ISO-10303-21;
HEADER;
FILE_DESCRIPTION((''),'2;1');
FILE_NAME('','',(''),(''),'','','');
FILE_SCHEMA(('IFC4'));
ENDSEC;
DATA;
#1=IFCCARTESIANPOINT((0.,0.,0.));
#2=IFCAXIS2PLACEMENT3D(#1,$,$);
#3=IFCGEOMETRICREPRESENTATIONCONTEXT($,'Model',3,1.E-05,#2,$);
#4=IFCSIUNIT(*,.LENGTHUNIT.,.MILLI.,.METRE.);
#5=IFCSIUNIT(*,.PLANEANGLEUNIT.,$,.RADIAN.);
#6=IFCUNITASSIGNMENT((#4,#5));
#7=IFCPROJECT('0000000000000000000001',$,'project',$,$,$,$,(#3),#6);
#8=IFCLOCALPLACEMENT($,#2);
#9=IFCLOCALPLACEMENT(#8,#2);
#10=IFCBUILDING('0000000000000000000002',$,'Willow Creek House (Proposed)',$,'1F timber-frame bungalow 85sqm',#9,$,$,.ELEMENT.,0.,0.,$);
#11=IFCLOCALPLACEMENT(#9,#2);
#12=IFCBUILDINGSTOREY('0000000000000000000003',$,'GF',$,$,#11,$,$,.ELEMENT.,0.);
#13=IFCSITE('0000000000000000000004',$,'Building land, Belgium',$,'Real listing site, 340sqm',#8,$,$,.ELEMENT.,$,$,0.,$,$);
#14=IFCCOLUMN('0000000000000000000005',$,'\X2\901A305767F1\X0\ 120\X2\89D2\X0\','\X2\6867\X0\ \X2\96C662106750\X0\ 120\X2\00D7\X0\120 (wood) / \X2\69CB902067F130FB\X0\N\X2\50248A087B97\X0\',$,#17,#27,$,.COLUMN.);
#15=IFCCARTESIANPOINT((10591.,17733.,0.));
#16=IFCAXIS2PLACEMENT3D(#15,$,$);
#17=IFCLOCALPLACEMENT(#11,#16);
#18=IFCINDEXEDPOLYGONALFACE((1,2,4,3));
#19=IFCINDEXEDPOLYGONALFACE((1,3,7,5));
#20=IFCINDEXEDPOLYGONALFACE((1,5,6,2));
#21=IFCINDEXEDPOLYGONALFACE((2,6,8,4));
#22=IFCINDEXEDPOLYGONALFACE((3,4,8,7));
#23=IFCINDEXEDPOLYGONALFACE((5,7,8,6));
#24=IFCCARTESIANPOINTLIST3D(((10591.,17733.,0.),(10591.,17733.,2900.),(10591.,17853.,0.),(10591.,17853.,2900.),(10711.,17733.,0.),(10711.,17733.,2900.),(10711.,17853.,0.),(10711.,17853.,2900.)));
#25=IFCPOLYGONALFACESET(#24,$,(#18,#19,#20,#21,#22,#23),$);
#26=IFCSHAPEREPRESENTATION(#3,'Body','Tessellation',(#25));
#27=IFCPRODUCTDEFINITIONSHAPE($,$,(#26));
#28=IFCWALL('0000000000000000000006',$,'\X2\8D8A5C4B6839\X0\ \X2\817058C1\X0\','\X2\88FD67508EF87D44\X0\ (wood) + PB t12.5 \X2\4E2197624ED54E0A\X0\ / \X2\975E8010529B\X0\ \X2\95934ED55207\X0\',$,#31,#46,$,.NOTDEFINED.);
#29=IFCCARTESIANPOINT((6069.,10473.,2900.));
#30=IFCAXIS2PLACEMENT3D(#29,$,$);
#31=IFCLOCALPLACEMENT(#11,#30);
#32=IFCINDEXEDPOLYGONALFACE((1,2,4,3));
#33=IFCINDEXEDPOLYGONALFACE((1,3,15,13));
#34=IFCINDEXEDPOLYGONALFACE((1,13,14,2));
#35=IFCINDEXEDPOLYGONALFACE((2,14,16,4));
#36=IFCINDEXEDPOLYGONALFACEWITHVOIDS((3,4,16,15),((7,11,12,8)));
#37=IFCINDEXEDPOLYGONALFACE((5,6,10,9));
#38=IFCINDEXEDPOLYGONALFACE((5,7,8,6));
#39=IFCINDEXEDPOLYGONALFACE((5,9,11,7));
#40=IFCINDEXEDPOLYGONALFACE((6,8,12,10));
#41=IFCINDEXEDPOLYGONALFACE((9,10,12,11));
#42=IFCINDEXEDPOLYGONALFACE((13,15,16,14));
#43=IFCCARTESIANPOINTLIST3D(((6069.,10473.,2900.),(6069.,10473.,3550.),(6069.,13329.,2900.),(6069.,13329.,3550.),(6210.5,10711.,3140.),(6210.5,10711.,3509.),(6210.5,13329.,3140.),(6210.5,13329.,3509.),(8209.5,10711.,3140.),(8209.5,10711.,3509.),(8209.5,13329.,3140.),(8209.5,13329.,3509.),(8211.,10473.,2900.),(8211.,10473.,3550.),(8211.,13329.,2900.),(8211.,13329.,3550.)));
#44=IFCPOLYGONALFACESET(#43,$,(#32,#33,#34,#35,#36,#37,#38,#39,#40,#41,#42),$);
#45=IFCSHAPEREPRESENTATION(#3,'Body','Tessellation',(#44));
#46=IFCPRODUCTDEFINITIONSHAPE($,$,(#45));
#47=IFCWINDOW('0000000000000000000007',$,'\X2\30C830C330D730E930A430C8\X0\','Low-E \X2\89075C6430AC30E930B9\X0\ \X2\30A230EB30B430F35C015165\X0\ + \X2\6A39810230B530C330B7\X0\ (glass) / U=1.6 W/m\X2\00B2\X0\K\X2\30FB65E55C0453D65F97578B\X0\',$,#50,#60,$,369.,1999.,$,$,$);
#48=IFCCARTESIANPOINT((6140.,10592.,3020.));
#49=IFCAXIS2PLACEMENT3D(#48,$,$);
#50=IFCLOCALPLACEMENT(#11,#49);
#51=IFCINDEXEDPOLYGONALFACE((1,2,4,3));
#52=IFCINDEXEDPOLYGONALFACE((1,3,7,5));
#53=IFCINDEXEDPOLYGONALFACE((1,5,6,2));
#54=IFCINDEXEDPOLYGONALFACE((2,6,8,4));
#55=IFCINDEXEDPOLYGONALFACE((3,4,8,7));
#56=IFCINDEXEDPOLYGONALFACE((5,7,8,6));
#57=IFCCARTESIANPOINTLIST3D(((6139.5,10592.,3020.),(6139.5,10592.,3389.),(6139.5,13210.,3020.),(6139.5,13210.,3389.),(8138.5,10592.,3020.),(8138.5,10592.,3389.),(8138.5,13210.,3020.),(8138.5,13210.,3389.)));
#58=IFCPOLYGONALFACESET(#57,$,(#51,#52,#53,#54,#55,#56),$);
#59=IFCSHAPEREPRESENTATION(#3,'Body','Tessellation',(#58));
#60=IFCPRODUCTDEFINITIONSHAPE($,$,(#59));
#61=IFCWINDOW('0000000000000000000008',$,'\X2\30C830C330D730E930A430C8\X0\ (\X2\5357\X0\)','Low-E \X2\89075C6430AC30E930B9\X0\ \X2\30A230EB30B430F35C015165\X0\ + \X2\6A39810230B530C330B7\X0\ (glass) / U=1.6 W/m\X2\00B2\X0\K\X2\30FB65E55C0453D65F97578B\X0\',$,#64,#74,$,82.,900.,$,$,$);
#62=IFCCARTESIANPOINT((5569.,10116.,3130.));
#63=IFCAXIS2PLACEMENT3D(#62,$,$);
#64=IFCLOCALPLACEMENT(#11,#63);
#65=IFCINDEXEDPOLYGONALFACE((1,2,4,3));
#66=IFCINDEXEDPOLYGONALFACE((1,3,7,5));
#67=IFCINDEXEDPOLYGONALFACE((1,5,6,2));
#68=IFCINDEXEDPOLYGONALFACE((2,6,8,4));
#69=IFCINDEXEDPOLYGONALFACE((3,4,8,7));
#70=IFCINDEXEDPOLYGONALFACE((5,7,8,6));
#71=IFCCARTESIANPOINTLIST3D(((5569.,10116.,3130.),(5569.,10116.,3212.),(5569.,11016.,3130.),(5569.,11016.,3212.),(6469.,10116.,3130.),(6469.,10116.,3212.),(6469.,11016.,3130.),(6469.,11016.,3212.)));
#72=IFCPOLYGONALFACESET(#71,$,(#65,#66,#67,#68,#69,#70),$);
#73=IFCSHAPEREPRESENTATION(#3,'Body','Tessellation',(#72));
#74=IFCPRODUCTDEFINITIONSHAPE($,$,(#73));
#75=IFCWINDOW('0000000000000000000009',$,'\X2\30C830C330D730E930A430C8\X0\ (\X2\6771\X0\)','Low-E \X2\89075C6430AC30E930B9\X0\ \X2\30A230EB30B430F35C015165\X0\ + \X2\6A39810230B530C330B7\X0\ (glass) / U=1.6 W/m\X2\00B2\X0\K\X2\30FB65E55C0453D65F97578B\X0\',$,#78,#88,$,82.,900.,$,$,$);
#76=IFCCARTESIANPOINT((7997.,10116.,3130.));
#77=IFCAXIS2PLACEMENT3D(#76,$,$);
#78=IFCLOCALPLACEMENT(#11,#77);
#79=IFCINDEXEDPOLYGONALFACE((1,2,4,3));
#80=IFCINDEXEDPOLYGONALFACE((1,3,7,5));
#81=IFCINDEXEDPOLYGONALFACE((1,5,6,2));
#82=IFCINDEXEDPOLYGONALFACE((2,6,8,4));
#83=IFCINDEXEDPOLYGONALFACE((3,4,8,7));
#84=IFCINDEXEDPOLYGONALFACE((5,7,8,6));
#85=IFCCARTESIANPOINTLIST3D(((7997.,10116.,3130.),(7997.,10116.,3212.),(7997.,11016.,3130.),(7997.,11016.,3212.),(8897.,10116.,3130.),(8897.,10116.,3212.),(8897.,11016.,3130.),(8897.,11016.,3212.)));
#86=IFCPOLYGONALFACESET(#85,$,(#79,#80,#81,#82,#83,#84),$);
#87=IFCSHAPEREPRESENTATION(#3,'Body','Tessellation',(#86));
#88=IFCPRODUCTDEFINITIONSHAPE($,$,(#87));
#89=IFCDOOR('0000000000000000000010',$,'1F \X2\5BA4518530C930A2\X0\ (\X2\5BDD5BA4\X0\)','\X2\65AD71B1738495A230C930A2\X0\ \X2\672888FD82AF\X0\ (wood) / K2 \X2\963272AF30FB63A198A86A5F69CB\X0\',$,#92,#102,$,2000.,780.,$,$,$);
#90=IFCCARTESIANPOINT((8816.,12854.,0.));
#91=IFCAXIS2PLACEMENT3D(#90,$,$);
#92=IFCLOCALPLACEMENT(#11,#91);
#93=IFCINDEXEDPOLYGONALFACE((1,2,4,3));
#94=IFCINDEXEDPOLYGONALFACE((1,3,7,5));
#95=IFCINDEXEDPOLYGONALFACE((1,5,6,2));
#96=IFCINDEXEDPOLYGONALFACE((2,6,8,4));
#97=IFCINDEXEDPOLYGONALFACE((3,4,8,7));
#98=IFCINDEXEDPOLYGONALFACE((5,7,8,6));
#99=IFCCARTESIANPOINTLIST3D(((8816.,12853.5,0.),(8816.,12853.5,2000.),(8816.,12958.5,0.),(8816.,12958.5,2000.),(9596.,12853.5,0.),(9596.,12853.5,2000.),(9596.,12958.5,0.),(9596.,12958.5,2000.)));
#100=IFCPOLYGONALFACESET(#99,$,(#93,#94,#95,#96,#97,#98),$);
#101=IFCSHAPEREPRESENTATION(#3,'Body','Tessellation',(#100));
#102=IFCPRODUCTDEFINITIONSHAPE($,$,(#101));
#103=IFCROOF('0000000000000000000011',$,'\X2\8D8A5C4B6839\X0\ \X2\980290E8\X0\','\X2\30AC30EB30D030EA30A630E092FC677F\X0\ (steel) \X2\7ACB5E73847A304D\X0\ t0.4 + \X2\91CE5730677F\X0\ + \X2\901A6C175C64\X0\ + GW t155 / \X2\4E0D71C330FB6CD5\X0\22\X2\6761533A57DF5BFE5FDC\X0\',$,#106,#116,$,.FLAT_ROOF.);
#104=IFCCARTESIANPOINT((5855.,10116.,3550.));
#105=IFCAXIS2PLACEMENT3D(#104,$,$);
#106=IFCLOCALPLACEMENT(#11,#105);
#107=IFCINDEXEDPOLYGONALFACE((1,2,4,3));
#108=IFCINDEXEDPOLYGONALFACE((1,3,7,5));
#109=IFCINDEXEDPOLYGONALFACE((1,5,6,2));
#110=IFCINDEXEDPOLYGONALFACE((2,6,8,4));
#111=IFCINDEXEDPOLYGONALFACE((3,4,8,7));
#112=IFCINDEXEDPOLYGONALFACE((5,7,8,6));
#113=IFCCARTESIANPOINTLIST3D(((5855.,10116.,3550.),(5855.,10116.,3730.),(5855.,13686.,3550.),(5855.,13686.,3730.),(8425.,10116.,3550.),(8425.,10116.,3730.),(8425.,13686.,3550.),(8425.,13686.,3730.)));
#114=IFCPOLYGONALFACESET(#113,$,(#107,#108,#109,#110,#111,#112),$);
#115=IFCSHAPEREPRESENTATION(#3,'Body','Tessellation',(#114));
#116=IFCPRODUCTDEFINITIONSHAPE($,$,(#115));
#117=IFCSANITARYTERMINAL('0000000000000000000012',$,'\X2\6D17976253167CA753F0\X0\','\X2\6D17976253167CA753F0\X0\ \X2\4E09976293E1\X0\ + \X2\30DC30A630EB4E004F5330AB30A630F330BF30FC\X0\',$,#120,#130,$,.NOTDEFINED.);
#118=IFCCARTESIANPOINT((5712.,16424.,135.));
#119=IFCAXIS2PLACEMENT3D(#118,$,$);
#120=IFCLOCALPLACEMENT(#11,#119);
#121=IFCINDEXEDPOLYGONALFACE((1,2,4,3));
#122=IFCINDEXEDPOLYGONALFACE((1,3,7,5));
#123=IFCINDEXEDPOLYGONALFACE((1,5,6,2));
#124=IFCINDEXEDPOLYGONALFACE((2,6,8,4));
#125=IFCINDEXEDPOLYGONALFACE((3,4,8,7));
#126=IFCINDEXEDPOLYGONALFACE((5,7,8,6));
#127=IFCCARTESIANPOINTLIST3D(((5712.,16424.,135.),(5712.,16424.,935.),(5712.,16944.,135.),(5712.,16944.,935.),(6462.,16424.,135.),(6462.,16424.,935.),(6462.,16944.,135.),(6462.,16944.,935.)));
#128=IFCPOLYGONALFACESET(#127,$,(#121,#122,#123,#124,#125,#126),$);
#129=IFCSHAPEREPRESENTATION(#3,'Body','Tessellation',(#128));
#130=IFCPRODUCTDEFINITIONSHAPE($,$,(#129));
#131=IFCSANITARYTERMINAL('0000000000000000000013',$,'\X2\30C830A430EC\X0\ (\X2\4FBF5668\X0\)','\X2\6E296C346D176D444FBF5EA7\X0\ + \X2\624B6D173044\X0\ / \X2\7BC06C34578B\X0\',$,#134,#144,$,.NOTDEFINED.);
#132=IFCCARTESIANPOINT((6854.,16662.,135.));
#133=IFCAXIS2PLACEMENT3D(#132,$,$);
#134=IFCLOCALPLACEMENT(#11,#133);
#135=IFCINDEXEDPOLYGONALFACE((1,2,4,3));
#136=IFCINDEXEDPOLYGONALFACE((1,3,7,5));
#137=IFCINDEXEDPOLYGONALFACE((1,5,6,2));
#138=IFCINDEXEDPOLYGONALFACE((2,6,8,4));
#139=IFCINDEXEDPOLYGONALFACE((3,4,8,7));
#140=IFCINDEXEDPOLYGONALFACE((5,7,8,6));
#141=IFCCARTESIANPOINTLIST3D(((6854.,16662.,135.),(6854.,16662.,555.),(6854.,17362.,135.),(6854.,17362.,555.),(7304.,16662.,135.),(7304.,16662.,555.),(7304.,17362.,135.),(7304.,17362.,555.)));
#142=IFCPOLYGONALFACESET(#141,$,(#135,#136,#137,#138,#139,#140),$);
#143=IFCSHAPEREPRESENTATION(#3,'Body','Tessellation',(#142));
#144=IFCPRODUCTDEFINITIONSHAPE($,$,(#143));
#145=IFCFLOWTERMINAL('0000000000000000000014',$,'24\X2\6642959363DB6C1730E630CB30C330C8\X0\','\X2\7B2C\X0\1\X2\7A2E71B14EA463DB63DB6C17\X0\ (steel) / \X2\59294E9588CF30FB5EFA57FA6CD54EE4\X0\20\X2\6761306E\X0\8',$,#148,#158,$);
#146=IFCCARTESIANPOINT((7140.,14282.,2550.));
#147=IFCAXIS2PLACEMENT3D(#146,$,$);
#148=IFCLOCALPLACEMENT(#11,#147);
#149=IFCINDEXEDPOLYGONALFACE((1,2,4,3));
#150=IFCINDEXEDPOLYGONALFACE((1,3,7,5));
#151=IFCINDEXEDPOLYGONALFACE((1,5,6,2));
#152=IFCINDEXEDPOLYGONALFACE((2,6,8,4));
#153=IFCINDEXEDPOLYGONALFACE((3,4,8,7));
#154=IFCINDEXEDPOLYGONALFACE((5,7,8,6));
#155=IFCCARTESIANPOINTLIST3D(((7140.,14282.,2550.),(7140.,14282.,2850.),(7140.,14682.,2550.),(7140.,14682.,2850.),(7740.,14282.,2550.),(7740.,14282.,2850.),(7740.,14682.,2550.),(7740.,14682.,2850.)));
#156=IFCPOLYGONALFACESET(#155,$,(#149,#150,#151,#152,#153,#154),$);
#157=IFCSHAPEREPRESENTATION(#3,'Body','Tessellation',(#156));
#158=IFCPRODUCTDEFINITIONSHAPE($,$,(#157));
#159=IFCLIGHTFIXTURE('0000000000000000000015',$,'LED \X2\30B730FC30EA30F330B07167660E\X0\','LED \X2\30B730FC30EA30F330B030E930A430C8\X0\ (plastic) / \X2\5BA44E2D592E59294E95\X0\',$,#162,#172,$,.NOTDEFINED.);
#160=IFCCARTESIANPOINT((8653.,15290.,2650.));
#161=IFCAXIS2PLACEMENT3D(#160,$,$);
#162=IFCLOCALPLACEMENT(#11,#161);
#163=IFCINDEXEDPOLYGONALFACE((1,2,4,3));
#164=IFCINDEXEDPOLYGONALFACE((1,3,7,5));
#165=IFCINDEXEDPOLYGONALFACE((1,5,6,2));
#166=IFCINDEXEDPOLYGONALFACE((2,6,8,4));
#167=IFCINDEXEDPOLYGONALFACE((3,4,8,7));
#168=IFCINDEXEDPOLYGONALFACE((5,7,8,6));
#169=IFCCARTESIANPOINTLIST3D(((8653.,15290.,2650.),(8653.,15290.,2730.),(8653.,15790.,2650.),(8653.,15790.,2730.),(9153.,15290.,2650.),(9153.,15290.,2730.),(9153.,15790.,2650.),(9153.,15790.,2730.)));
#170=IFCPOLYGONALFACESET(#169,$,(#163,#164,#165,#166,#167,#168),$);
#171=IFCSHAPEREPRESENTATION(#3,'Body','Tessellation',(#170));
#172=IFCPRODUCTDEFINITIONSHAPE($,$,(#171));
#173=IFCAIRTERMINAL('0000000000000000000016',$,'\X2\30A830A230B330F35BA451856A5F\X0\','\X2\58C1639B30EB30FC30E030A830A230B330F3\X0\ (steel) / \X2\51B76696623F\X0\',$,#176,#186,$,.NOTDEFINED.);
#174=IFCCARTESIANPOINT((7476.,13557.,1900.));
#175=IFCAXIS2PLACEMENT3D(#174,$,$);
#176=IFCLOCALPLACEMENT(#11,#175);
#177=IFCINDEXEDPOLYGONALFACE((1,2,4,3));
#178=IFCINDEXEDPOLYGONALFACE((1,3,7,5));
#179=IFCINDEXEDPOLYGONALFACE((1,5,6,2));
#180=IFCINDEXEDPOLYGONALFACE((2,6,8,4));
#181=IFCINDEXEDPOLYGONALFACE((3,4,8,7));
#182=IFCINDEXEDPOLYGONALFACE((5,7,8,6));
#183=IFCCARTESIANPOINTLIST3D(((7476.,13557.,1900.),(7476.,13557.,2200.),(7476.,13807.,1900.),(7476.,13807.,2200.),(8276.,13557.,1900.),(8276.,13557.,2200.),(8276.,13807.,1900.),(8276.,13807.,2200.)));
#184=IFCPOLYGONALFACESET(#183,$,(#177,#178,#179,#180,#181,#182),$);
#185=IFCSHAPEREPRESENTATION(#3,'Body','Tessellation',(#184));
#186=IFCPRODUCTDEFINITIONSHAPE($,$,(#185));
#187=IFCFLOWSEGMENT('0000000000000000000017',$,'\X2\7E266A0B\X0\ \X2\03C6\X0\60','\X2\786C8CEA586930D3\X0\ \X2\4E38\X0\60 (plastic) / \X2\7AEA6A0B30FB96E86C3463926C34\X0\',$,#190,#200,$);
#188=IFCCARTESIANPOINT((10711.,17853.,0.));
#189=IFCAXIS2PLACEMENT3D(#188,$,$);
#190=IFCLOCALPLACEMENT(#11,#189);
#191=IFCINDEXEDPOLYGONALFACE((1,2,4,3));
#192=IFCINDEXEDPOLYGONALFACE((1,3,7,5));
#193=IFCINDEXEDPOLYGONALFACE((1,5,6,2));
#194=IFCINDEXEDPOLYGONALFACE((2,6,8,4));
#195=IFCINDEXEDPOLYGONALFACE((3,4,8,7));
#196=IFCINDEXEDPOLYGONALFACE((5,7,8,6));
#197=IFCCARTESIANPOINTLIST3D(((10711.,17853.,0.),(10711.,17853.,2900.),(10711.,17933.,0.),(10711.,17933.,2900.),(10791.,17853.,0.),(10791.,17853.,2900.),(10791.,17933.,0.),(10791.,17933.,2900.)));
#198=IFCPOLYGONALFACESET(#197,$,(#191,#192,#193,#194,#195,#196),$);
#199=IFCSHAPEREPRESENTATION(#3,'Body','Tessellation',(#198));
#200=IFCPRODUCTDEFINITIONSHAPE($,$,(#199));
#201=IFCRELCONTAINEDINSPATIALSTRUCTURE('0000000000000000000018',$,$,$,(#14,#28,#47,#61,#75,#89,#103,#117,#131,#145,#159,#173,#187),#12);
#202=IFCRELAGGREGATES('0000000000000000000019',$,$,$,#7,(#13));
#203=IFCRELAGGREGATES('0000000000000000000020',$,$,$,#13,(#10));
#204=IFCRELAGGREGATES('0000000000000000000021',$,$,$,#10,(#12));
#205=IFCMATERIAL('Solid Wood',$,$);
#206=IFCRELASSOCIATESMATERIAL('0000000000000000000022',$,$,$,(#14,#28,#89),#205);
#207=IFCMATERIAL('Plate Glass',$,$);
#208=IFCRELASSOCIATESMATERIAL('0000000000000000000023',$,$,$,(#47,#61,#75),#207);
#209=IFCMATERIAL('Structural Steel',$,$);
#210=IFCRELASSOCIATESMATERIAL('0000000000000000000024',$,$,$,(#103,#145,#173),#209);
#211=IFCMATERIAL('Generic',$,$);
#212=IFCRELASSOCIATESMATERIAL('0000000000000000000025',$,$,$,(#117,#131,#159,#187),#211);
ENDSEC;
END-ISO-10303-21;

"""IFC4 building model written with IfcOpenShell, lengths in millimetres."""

from ifc_helpers import new_model, si_unit, frame, frame_2d, origin, place, context, project, spatial, rectangle, extrude, material, element, fill, save


model = new_model("IFC4")

# Units and contexts
model_context = context("Model", 3, precision=1e-05, world=origin())
ifc_project = project(units=[si_unit("LENGTHUNIT", "METRE", prefix="MILLI"), si_unit("PLANEANGLEUNIT", "RADIAN")], contexts=[model_context])

# Site, building, storey
site_placement = place(None, origin())
site = spatial("IfcSite", under=ifc_project, at=site_placement, Name="Building land, Belgium", ObjectType="Real listing site, 340sqm", CompositionType="ELEMENT", RefElevation=0.0)
building_placement = place(site_placement, origin())
building = spatial("IfcBuilding", under=site, at=building_placement, Name="Willow Creek House (Proposed)", ObjectType="1F timber-frame bungalow 85sqm", CompositionType="ELEMENT", ElevationOfRefHeight=0.0, ElevationOfTerrain=0.0)
storey_placement = place(building_placement, origin())
storey = spatial("IfcBuildingStorey", under=building, at=storey_placement, Name="GF", CompositionType="ELEMENT", Elevation=0.0)

# Column
ifc_material_1 = material(Name="Solid Wood")
column_1_placement = place(storey_placement, frame((10591.0, 17733.0, 0.0)))
element("IfcColumn", 1, at=column_1_placement, inside=storey, material=ifc_material_1, Name="通し柱 120角", Description="桧 集成材 120×120 (wood) / 構造柱・N値計算", PredefinedType="COLUMN", context=model_context, shape_type="SweptSolid", body=[
    extrude(rectangle(XDim=120.0, YDim=120.0, at=frame_2d((60.0, 60.0))), frame((10591.0, 17733.0, 0.0)), (0.0, 0.0, 1.0), 2900.0),
])

# Wall, openings, windows
wall_1_placement = place(storey_placement, frame((6069.0, 10473.0, 2900.0)))
wall_1 = element("IfcWall", 2, at=wall_1_placement, inside=storey, material=ifc_material_1, Name="越屋根 腰壁", Description="製材軸組 (wood) + PB t12.5 両面仕上 / 非耐力 間仕切", PredefinedType="NOTDEFINED", context=model_context, shape_type="SweptSolid", body=[
    extrude(rectangle(XDim=2142.0, YDim=2856.0, at=frame_2d((1071.0, 1428.0))), frame((6069.0, 10473.0, 2900.0)), (0.0, 0.0, 1.0), 650.0),
])
opening_1_placement = place(storey_placement, frame((6140.0, 10592.0, 3020.0)))
opening_1 = element("IfcOpeningElement", 3, at=opening_1_placement, cuts=wall_1, PredefinedType="NOTDEFINED", context=model_context, shape_type="SweptSolid", body=[
    extrude(rectangle(XDim=1999.0, YDim=2618.0, at=frame_2d((999.0, 1309.0))), frame((6140.0, 10592.0, 3020.0)), (0.0, 0.0, 1.0), 369.0),
])
opening_2_placement = place(storey_placement, frame((5569.0, 10116.0, 3130.0)))
opening_2 = element("IfcOpeningElement", 4, at=opening_2_placement, cuts=wall_1, PredefinedType="NOTDEFINED", context=model_context, shape_type="SweptSolid", body=[
    extrude(rectangle(XDim=900.0, YDim=900.0, at=frame_2d((450.0, 450.0))), frame((5569.0, 10116.0, 3130.0)), (0.0, 0.0, 1.0), 82.0),
])
opening_3_placement = place(storey_placement, frame((7997.0, 10116.0, 3130.0)))
opening_3 = element("IfcOpeningElement", 5, at=opening_3_placement, cuts=wall_1, PredefinedType="NOTDEFINED", context=model_context, shape_type="SweptSolid", body=[
    extrude(rectangle(XDim=900.0, YDim=900.0, at=frame_2d((450.0, 450.0))), frame((7997.0, 10116.0, 3130.0)), (0.0, 0.0, 1.0), 82.0),
])
ifc_material_2 = material(Name="Plate Glass")
window_1_placement = place(storey_placement, frame((6140.0, 10592.0, 3020.0)))
window_1 = element("IfcWindow", 6, at=window_1_placement, inside=storey, material=ifc_material_2, Name="トップライト", Description="Low-E 複層ガラス アルゴン封入 + 樹脂サッシ (glass) / U=1.6 W/m²K・日射取得型", OverallHeight=369.0, OverallWidth=1999.0, context=model_context, shape_type="SweptSolid", body=[
    extrude(rectangle(XDim=1999.0, YDim=2618.0, at=frame_2d((999.0, 1309.0))), frame((6140.0, 10592.0, 3020.0)), (0.0, 0.0, 1.0), 369.0),
])
fill(opening_1, window_1)
window_2_placement = place(storey_placement, frame((5569.0, 10116.0, 3130.0)))
window_2 = element("IfcWindow", 7, at=window_2_placement, inside=storey, material=ifc_material_2, Name="トップライト (南)", Description="Low-E 複層ガラス アルゴン封入 + 樹脂サッシ (glass) / U=1.6 W/m²K・日射取得型", OverallHeight=82.0, OverallWidth=900.0, context=model_context, shape_type="SweptSolid", body=[
    extrude(rectangle(XDim=900.0, YDim=900.0, at=frame_2d((450.0, 450.0))), frame((5569.0, 10116.0, 3130.0)), (0.0, 0.0, 1.0), 82.0),
])
fill(opening_2, window_2)
window_3_placement = place(storey_placement, frame((7997.0, 10116.0, 3130.0)))
window_3 = element("IfcWindow", 8, at=window_3_placement, inside=storey, material=ifc_material_2, Name="トップライト (東)", Description="Low-E 複層ガラス アルゴン封入 + 樹脂サッシ (glass) / U=1.6 W/m²K・日射取得型", OverallHeight=82.0, OverallWidth=900.0, context=model_context, shape_type="SweptSolid", body=[
    extrude(rectangle(XDim=900.0, YDim=900.0, at=frame_2d((450.0, 450.0))), frame((7997.0, 10116.0, 3130.0)), (0.0, 0.0, 1.0), 82.0),
])
fill(opening_3, window_3)

# Door
door_placement = place(storey_placement, frame((8816.0, 12854.0, 0.0)))
element("IfcDoor", 9, at=door_placement, inside=storey, material=ifc_material_1, Name="1F 室内ドア (寝室)", Description="断熱玄関ドア 木製芯 (wood) / K2 防犯・採風機構", OverallHeight=2000.0, OverallWidth=780.0, context=model_context, shape_type="SweptSolid", body=[
    extrude(rectangle(XDim=780.0, YDim=105.0, at=frame_2d((390.0, 52.0))), frame((8816.0, 12854.0, 0.0)), (0.0, 0.0, 1.0), 2000.0),
])

# Roof
ifc_material_3 = material(Name="Structural Steel")
roof_placement = place(storey_placement, frame((5855.0, 10116.0, 3550.0)))
element("IfcRoof", 10, at=roof_placement, inside=storey, material=ifc_material_3, Name="越屋根 頂部", Description="ガルバリウム鋼板 (steel) 立平葺き t0.4 + 野地板 + 通気層 + GW t155 / 不燃・法22条区域対応", PredefinedType="FLAT_ROOF", context=model_context, shape_type="SweptSolid", body=[
    extrude(rectangle(XDim=2570.0, YDim=3570.0, at=frame_2d((1285.0, 1785.0))), frame((5855.0, 10116.0, 3550.0)), (0.0, 0.0, 1.0), 180.0),
])

# Sanitary terminals
ifc_material_4 = material(Name="Generic")
sanitary_terminal_1_placement = place(storey_placement, frame((5712.0, 16424.0, 135.0)))
element("IfcSanitaryTerminal", 11, at=sanitary_terminal_1_placement, inside=storey, material=ifc_material_4, Name="洗面化粧台", Description="洗面化粧台 三面鏡 + ボウル一体カウンター", PredefinedType="NOTDEFINED", context=model_context, shape_type="SweptSolid", body=[
    extrude(rectangle(XDim=750.0, YDim=520.0, at=frame_2d((375.0, 260.0))), frame((5712.0, 16424.0, 135.0)), (0.0, 0.0, 1.0), 800.0),
])
sanitary_terminal_2_placement = place(storey_placement, frame((6854.0, 16662.0, 135.0)))
element("IfcSanitaryTerminal", 12, at=sanitary_terminal_2_placement, inside=storey, material=ifc_material_4, Name="トイレ (便器)", Description="温水洗浄便座 + 手洗い / 節水型", PredefinedType="NOTDEFINED", context=model_context, shape_type="SweptSolid", body=[
    extrude(rectangle(XDim=450.0, YDim=700.0, at=frame_2d((225.0, 350.0))), frame((6854.0, 16662.0, 135.0)), (0.0, 0.0, 1.0), 420.0),
])

# Flow terminal
flow_terminal_placement = place(storey_placement, frame((7140.0, 14282.0, 2550.0)))
element("IfcFlowTerminal", 13, at=flow_terminal_placement, inside=storey, material=ifc_material_3, Name="24時間換気ユニット", Description="第1種熱交換換気 (steel) / 天井裏・建基法令20条の8", context=model_context, shape_type="SweptSolid", body=[
    extrude(rectangle(XDim=600.0, YDim=400.0, at=frame_2d((300.0, 200.0))), frame((7140.0, 14282.0, 2550.0)), (0.0, 0.0, 1.0), 300.0),
])

# Light fixture
light_fixture_placement = place(storey_placement, frame((8653.0, 15290.0, 2650.0)))
element("IfcLightFixture", 14, at=light_fixture_placement, inside=storey, material=ifc_material_4, Name="LED シーリング照明", Description="LED シーリングライト (plastic) / 室中央天井", PredefinedType="NOTDEFINED", context=model_context, shape_type="SweptSolid", body=[
    extrude(rectangle(XDim=500.0, YDim=500.0, at=frame_2d((250.0, 250.0))), frame((8653.0, 15290.0, 2650.0)), (0.0, 0.0, 1.0), 80.0),
])

# Air terminal
air_terminal_placement = place(storey_placement, frame((7476.0, 13557.0, 1900.0)))
element("IfcAirTerminal", 15, at=air_terminal_placement, inside=storey, material=ifc_material_3, Name="エアコン室内機", Description="壁掛ルームエアコン (steel) / 冷暖房", PredefinedType="NOTDEFINED", context=model_context, shape_type="SweptSolid", body=[
    extrude(rectangle(XDim=800.0, YDim=250.0, at=frame_2d((400.0, 125.0))), frame((7476.0, 13557.0, 1900.0)), (0.0, 0.0, 1.0), 300.0),
])

# Flow segment
flow_segment_placement = place(storey_placement, frame((10711.0, 17853.0, 0.0)))
element("IfcFlowSegment", 16, at=flow_segment_placement, inside=storey, material=ifc_material_4, Name="縦樋 φ60", Description="硬質塩ビ 丸60 (plastic) / 竪樋・雨水排水", context=model_context, shape_type="SweptSolid", body=[
    extrude(rectangle(XDim=80.0, YDim=80.0, at=frame_2d((40.0, 40.0))), frame((10711.0, 17853.0, 0.0)), (0.0, 0.0, 1.0), 2900.0),
])

save(model, "model.ifc")
